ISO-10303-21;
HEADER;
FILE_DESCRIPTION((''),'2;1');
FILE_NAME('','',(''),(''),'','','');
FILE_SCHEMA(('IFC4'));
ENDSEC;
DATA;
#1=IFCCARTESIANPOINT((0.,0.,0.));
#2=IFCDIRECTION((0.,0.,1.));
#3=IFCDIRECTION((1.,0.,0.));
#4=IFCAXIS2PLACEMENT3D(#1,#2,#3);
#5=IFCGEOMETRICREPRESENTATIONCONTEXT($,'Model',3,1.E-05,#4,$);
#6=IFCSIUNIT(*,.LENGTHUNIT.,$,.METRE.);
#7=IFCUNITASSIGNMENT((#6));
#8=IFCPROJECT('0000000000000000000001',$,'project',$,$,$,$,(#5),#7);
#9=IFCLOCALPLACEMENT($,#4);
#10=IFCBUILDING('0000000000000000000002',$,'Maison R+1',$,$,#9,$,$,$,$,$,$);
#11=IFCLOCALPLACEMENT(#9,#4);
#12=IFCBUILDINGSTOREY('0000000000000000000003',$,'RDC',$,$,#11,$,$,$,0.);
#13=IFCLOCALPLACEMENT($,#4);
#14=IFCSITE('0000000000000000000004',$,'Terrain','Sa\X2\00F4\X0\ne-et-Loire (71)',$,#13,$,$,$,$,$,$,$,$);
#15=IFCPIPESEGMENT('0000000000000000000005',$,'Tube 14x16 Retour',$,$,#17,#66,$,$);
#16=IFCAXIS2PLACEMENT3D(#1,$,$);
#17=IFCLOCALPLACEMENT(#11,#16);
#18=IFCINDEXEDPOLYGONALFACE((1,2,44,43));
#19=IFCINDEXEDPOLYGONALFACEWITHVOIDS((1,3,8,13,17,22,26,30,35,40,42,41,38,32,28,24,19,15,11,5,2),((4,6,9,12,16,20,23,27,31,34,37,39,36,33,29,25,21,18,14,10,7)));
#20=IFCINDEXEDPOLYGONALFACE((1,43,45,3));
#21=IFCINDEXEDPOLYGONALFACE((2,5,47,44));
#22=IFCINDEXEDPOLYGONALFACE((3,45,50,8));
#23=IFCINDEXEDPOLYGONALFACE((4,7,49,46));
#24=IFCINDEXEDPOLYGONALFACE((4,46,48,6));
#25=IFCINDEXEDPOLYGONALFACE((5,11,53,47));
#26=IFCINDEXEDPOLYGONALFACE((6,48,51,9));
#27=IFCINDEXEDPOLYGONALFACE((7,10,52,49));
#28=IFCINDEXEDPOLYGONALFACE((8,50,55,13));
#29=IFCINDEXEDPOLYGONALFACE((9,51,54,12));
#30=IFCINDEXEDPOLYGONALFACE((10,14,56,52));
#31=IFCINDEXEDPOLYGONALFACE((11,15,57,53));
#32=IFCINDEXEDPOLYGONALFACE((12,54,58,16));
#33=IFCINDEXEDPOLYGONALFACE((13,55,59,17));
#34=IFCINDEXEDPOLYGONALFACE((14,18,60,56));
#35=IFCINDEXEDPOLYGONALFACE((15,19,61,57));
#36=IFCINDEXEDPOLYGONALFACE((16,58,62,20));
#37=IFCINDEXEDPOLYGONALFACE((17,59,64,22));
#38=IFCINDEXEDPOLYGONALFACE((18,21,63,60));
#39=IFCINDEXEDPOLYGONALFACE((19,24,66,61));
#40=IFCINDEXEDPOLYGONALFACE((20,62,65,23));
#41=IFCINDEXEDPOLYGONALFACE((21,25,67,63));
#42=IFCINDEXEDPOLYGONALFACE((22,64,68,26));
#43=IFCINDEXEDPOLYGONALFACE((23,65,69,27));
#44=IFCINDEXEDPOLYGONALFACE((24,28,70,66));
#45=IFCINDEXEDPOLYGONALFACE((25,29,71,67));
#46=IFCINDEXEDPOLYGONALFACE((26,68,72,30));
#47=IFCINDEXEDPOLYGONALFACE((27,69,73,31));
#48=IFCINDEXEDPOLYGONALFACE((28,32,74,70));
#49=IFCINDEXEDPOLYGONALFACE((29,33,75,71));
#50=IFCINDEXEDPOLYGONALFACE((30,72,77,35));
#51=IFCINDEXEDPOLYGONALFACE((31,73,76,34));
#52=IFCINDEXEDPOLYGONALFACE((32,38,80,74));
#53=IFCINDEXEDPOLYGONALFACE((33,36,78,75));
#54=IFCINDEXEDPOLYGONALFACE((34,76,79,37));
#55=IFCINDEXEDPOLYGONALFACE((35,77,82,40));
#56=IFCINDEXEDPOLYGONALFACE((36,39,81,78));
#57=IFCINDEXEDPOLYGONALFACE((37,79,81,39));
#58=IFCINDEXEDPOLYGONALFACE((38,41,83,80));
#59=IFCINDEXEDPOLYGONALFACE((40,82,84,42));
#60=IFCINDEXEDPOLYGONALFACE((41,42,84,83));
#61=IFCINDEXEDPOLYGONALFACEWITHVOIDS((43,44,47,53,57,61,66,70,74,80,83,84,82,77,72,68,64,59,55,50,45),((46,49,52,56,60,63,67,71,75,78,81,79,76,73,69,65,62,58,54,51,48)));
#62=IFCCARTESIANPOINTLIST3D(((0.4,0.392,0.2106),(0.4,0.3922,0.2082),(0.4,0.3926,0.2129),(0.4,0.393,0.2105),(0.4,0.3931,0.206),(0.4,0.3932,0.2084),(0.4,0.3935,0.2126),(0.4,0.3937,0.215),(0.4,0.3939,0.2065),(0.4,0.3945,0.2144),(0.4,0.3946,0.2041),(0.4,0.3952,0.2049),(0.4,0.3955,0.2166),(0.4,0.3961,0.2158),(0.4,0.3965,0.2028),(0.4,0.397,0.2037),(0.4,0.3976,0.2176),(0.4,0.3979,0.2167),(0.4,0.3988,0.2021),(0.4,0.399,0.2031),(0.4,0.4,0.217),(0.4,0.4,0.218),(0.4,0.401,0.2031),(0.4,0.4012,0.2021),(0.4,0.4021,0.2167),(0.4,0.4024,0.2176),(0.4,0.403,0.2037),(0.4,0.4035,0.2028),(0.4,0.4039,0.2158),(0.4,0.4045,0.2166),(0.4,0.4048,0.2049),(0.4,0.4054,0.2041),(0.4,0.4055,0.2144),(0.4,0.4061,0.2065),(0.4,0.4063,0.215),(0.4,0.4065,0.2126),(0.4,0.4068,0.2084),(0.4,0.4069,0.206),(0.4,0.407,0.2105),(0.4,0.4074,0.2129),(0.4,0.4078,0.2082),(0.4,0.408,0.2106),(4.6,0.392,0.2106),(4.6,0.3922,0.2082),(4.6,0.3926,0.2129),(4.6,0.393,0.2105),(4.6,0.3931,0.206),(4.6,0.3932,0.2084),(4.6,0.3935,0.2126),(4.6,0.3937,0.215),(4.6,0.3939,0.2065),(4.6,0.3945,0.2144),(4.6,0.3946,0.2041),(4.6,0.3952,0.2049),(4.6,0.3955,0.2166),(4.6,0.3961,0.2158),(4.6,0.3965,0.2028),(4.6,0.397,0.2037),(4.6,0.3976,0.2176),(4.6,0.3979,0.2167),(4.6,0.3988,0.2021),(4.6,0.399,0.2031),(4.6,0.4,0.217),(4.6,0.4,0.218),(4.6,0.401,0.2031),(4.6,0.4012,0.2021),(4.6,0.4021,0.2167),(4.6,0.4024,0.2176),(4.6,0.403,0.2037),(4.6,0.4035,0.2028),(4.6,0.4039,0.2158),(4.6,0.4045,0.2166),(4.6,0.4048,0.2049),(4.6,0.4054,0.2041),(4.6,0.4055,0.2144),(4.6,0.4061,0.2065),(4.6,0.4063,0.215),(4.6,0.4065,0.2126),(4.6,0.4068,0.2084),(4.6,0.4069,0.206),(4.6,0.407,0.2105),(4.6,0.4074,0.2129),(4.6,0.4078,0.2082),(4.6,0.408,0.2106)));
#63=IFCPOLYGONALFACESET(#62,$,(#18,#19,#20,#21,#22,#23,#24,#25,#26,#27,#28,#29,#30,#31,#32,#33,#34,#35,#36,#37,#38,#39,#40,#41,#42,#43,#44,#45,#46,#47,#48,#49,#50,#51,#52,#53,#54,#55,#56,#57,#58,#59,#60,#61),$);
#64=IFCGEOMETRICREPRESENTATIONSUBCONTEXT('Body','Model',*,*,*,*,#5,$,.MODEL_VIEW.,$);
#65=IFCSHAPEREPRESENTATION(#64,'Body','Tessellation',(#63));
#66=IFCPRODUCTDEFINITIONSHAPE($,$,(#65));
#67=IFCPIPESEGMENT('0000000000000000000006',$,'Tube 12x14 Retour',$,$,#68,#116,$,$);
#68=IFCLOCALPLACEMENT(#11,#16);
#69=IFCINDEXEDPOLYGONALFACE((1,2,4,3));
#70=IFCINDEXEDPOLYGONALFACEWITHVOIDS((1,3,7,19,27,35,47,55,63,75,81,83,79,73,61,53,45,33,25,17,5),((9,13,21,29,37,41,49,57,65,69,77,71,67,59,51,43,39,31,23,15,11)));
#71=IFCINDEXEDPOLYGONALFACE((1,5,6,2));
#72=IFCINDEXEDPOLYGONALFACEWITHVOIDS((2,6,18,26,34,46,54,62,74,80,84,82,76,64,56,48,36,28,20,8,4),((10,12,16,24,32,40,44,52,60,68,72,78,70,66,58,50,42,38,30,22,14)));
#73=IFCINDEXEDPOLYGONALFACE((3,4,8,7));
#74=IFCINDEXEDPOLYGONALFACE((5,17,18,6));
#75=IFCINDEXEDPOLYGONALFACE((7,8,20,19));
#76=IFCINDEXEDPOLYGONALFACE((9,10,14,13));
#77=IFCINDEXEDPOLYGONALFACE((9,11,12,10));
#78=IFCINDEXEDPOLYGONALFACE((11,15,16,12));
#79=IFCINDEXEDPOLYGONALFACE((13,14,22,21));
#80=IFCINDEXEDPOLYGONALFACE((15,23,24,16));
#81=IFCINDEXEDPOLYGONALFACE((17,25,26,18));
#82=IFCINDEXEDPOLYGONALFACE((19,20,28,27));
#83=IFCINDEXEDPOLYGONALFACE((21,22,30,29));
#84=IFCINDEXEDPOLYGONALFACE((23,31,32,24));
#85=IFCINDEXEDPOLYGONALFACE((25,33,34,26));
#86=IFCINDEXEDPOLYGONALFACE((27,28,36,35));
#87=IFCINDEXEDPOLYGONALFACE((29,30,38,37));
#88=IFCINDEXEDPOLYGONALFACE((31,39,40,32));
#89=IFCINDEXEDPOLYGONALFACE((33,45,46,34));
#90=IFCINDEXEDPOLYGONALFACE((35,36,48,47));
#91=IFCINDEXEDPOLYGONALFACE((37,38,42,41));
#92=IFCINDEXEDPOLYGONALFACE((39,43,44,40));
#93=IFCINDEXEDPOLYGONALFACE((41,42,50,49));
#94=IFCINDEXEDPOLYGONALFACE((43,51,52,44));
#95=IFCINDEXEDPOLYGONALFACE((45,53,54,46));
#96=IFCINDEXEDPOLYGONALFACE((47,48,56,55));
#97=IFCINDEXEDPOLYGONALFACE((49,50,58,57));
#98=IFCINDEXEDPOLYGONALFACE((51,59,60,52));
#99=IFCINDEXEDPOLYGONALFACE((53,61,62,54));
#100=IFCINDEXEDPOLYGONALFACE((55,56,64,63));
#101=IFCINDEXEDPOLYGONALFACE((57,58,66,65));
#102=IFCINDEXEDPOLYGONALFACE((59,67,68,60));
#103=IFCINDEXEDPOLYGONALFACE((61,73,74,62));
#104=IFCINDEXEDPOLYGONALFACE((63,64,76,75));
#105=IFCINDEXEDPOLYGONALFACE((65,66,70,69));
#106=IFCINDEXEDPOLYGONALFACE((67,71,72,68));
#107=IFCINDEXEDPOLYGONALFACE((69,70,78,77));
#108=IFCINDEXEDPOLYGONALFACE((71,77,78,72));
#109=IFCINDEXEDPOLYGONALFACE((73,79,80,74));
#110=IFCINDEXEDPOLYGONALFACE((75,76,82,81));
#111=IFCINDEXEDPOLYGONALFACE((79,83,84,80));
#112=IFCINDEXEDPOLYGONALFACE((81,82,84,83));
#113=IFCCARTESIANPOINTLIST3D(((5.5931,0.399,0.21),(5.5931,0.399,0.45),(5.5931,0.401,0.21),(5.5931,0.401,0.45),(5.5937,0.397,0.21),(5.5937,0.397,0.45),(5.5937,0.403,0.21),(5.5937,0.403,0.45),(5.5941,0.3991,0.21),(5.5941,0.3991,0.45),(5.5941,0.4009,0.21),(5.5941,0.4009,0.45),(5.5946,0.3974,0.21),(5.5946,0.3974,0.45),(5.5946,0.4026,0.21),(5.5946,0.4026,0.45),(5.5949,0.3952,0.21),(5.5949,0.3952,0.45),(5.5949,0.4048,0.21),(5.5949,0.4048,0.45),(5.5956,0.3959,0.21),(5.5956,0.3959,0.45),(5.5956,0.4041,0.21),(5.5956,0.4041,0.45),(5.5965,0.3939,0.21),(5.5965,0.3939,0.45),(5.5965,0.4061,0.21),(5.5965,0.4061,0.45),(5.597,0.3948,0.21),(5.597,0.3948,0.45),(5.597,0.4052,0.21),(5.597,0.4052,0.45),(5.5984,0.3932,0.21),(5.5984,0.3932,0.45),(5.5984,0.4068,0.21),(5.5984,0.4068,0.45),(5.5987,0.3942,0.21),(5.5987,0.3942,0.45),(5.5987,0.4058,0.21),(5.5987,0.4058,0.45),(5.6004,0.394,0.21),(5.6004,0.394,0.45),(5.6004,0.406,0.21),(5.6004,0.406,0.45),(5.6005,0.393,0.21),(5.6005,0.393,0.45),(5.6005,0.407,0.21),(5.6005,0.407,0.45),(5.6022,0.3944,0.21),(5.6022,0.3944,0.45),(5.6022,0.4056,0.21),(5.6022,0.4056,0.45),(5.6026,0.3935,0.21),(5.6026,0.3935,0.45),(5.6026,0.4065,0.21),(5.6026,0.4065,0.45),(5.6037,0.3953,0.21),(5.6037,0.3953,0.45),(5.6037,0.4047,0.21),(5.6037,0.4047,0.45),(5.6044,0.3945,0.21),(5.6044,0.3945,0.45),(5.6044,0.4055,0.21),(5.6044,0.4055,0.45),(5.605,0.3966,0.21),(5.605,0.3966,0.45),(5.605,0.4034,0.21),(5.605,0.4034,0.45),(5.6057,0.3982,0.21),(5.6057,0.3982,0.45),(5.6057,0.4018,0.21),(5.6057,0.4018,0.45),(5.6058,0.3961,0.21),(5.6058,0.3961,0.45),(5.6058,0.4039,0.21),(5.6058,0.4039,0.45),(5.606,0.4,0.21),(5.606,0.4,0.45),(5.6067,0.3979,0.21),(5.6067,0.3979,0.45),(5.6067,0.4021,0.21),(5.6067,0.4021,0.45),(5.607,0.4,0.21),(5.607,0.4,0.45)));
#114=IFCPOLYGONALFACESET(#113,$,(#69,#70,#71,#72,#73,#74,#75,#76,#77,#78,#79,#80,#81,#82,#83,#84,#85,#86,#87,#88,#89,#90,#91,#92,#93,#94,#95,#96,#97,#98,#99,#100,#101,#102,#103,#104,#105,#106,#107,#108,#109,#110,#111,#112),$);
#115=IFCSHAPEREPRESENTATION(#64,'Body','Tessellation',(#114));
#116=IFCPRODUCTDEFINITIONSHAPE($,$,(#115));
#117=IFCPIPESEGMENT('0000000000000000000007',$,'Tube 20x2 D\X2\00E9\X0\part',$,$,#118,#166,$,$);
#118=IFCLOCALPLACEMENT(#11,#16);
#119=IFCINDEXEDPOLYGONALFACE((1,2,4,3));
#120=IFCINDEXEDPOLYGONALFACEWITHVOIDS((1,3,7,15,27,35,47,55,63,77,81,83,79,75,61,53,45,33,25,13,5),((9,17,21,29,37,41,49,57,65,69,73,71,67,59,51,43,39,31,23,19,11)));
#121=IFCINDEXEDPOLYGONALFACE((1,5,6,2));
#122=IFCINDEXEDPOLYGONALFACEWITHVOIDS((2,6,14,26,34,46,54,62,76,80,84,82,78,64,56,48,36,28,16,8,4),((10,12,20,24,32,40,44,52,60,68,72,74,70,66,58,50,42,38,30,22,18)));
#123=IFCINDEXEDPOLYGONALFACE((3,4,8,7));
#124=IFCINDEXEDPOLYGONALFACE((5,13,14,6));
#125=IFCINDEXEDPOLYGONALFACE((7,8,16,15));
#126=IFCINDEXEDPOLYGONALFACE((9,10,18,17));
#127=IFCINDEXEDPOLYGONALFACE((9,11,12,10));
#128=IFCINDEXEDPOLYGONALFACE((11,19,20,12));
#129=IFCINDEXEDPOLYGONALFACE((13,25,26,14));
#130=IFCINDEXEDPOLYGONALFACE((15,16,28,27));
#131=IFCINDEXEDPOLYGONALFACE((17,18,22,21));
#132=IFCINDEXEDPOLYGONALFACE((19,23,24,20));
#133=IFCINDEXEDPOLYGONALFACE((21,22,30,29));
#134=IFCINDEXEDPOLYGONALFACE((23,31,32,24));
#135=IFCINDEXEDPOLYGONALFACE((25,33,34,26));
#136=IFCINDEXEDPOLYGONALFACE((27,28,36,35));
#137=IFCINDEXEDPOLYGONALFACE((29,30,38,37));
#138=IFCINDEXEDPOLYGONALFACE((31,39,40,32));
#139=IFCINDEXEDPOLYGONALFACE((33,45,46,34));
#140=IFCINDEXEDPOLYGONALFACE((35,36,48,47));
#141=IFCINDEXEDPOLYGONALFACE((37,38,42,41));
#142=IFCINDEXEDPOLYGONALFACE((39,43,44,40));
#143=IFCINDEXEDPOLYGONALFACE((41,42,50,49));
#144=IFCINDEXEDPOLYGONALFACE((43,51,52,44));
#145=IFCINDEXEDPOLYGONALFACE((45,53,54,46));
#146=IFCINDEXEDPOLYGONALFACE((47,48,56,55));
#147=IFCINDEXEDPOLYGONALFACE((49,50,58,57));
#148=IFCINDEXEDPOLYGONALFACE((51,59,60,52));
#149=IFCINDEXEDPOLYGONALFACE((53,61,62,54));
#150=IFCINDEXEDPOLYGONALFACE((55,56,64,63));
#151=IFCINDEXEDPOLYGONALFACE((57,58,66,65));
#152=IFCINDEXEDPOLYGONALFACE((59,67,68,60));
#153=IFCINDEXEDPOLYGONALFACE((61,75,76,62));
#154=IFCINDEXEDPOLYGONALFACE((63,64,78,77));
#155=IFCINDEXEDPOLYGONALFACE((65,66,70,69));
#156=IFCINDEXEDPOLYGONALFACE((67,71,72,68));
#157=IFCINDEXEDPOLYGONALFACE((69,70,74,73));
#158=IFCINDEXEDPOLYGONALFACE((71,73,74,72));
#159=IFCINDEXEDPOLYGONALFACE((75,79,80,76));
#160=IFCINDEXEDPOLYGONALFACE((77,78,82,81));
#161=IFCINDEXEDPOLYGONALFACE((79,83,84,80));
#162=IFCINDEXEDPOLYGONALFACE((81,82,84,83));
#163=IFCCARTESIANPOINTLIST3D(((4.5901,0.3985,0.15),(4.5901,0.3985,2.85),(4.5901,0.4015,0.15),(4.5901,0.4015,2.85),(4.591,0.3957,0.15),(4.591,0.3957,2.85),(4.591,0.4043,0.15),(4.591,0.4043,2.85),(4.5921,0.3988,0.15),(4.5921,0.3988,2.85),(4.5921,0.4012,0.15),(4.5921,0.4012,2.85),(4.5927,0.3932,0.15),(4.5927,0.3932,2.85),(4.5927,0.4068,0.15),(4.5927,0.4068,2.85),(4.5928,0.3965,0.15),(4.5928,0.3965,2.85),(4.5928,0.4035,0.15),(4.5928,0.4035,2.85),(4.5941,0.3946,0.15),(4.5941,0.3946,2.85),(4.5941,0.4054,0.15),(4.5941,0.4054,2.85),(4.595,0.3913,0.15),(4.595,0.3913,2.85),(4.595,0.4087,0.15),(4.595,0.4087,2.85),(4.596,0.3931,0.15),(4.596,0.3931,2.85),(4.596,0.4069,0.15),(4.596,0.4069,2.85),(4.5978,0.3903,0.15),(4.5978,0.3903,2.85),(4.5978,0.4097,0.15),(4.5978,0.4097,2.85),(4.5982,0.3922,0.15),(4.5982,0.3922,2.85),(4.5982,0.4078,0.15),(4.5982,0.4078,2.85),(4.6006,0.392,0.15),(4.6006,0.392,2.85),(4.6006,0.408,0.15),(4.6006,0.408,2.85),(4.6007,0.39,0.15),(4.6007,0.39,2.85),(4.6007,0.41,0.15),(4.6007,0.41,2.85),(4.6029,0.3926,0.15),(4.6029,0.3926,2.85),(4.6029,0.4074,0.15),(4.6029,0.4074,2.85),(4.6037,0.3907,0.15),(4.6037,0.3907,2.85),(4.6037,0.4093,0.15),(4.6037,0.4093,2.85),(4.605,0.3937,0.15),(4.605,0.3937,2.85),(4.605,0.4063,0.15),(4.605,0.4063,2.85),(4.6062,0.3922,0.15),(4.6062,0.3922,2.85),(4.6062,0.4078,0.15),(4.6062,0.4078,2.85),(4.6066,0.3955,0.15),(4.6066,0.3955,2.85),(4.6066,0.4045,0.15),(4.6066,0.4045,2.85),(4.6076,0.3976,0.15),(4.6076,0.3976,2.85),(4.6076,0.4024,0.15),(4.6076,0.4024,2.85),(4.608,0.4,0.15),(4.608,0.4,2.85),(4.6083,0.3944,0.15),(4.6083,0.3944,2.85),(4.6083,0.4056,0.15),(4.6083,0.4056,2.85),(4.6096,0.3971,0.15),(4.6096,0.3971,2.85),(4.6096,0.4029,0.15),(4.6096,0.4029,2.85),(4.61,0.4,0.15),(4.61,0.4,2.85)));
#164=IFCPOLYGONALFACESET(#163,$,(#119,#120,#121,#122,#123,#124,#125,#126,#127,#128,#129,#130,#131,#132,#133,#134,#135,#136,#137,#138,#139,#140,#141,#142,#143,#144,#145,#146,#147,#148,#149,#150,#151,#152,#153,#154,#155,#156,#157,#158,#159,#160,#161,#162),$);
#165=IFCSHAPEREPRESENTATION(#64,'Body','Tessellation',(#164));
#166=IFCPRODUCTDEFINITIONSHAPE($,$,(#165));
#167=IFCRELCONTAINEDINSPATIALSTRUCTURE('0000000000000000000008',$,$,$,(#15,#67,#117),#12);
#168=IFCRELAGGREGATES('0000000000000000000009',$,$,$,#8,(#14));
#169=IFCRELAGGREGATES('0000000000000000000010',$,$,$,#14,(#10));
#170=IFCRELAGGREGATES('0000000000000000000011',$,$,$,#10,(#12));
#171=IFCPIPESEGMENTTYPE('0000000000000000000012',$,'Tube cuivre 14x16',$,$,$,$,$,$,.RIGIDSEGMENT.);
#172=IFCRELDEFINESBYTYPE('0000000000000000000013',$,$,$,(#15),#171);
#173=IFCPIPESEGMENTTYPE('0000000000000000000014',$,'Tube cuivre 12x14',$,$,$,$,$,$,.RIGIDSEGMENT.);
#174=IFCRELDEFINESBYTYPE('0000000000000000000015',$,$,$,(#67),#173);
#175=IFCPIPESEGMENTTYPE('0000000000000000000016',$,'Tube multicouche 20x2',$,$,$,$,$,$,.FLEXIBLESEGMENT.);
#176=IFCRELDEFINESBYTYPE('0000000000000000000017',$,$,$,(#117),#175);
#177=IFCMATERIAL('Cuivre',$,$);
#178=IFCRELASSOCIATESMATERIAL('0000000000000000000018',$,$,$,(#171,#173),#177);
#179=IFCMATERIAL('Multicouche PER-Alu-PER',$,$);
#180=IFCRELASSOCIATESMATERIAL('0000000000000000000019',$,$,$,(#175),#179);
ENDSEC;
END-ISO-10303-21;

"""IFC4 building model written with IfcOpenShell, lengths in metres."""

from ifc_helpers import new_model, si_unit, frame, origin_with_axes, place, context, subcontext, project, spatial, hollow_circle, extrude, material, type_object, element, save


model = new_model("IFC4")

# Units and contexts
model_context = context("Model", 3, precision=1e-05, world=origin_with_axes())
body_context = subcontext(model_context, "Body", "Model", "MODEL_VIEW")
ifc_project = project(units=[si_unit("LENGTHUNIT", "METRE")], contexts=[model_context])

# Site, building, storey
site_placement = place(None, origin_with_axes())
site = spatial("IfcSite", under=ifc_project, at=site_placement, Name="Terrain", Description="Saône-et-Loire (71)")
building_placement = place(None, origin_with_axes())
building = spatial("IfcBuilding", under=site, at=building_placement, Name="Maison R+1")
storey_placement = place(building_placement, origin_with_axes())
storey = spatial("IfcBuildingStorey", under=building, at=storey_placement, Name="RDC", Elevation=0.0)

# Pipe segments
ifc_material_1 = material(Name="Cuivre")
pipe_segment_type_1 = type_object("IfcPipeSegmentType", Name="Tube cuivre 14x16", PredefinedType="RIGIDSEGMENT", material=ifc_material_1)
for number, where, z_axis, x_axis, name in (
    (1, (4.6, 0.4, 0.21), (-1.0, 0.0, 0.0), (0.0, 0.0, 1.0), "Tube 14x16 Retour"),
):
    element("IfcPipeSegment", number, at=place(storey_placement, frame(where, z_axis=z_axis, x_axis=x_axis)), inside=storey, type_object=pipe_segment_type_1, Name=name, context=body_context, shape_type="SweptSolid", body=[
        extrude(hollow_circle(Radius=0.008, WallThickness=0.001), origin_with_axes(), (0.0, 0.0, 1.0), 4.2),
    ])
pipe_segment_type_2 = type_object("IfcPipeSegmentType", Name="Tube cuivre 12x14", PredefinedType="RIGIDSEGMENT", material=ifc_material_1)
pipe_segment_1_placement = place(storey_placement, frame((5.6, 0.4, 0.21), z_axis=(0.0, 0.0, 1.0), x_axis=(1.0, 0.0, 0.0)))
element("IfcPipeSegment", 2, at=pipe_segment_1_placement, inside=storey, type_object=pipe_segment_type_2, Name="Tube 12x14 Retour", context=body_context, shape_type="SweptSolid", body=[
    extrude(hollow_circle(Radius=0.007, WallThickness=0.001), origin_with_axes(), (0.0, 0.0, 1.0), 0.24),
])
ifc_material_2 = material(Name="Multicouche PER-Alu-PER")
pipe_segment_type_3 = type_object("IfcPipeSegmentType", Name="Tube multicouche 20x2", PredefinedType="FLEXIBLESEGMENT", material=ifc_material_2)
for number, where, z_axis, x_axis, name in (
    (3, (4.6, 0.4, 0.15), (0.0, 0.0, 1.0), (1.0, 0.0, 0.0), "Tube 20x2 Départ"),
):
    element("IfcPipeSegment", number, at=place(storey_placement, frame(where, z_axis=z_axis, x_axis=x_axis)), inside=storey, type_object=pipe_segment_type_3, Name=name, context=body_context, shape_type="SweptSolid", body=[
        extrude(hollow_circle(Radius=0.01, WallThickness=0.002), origin_with_axes(), (0.0, 0.0, 1.0), 2.7),
    ])

save(model, "model.ifc")
